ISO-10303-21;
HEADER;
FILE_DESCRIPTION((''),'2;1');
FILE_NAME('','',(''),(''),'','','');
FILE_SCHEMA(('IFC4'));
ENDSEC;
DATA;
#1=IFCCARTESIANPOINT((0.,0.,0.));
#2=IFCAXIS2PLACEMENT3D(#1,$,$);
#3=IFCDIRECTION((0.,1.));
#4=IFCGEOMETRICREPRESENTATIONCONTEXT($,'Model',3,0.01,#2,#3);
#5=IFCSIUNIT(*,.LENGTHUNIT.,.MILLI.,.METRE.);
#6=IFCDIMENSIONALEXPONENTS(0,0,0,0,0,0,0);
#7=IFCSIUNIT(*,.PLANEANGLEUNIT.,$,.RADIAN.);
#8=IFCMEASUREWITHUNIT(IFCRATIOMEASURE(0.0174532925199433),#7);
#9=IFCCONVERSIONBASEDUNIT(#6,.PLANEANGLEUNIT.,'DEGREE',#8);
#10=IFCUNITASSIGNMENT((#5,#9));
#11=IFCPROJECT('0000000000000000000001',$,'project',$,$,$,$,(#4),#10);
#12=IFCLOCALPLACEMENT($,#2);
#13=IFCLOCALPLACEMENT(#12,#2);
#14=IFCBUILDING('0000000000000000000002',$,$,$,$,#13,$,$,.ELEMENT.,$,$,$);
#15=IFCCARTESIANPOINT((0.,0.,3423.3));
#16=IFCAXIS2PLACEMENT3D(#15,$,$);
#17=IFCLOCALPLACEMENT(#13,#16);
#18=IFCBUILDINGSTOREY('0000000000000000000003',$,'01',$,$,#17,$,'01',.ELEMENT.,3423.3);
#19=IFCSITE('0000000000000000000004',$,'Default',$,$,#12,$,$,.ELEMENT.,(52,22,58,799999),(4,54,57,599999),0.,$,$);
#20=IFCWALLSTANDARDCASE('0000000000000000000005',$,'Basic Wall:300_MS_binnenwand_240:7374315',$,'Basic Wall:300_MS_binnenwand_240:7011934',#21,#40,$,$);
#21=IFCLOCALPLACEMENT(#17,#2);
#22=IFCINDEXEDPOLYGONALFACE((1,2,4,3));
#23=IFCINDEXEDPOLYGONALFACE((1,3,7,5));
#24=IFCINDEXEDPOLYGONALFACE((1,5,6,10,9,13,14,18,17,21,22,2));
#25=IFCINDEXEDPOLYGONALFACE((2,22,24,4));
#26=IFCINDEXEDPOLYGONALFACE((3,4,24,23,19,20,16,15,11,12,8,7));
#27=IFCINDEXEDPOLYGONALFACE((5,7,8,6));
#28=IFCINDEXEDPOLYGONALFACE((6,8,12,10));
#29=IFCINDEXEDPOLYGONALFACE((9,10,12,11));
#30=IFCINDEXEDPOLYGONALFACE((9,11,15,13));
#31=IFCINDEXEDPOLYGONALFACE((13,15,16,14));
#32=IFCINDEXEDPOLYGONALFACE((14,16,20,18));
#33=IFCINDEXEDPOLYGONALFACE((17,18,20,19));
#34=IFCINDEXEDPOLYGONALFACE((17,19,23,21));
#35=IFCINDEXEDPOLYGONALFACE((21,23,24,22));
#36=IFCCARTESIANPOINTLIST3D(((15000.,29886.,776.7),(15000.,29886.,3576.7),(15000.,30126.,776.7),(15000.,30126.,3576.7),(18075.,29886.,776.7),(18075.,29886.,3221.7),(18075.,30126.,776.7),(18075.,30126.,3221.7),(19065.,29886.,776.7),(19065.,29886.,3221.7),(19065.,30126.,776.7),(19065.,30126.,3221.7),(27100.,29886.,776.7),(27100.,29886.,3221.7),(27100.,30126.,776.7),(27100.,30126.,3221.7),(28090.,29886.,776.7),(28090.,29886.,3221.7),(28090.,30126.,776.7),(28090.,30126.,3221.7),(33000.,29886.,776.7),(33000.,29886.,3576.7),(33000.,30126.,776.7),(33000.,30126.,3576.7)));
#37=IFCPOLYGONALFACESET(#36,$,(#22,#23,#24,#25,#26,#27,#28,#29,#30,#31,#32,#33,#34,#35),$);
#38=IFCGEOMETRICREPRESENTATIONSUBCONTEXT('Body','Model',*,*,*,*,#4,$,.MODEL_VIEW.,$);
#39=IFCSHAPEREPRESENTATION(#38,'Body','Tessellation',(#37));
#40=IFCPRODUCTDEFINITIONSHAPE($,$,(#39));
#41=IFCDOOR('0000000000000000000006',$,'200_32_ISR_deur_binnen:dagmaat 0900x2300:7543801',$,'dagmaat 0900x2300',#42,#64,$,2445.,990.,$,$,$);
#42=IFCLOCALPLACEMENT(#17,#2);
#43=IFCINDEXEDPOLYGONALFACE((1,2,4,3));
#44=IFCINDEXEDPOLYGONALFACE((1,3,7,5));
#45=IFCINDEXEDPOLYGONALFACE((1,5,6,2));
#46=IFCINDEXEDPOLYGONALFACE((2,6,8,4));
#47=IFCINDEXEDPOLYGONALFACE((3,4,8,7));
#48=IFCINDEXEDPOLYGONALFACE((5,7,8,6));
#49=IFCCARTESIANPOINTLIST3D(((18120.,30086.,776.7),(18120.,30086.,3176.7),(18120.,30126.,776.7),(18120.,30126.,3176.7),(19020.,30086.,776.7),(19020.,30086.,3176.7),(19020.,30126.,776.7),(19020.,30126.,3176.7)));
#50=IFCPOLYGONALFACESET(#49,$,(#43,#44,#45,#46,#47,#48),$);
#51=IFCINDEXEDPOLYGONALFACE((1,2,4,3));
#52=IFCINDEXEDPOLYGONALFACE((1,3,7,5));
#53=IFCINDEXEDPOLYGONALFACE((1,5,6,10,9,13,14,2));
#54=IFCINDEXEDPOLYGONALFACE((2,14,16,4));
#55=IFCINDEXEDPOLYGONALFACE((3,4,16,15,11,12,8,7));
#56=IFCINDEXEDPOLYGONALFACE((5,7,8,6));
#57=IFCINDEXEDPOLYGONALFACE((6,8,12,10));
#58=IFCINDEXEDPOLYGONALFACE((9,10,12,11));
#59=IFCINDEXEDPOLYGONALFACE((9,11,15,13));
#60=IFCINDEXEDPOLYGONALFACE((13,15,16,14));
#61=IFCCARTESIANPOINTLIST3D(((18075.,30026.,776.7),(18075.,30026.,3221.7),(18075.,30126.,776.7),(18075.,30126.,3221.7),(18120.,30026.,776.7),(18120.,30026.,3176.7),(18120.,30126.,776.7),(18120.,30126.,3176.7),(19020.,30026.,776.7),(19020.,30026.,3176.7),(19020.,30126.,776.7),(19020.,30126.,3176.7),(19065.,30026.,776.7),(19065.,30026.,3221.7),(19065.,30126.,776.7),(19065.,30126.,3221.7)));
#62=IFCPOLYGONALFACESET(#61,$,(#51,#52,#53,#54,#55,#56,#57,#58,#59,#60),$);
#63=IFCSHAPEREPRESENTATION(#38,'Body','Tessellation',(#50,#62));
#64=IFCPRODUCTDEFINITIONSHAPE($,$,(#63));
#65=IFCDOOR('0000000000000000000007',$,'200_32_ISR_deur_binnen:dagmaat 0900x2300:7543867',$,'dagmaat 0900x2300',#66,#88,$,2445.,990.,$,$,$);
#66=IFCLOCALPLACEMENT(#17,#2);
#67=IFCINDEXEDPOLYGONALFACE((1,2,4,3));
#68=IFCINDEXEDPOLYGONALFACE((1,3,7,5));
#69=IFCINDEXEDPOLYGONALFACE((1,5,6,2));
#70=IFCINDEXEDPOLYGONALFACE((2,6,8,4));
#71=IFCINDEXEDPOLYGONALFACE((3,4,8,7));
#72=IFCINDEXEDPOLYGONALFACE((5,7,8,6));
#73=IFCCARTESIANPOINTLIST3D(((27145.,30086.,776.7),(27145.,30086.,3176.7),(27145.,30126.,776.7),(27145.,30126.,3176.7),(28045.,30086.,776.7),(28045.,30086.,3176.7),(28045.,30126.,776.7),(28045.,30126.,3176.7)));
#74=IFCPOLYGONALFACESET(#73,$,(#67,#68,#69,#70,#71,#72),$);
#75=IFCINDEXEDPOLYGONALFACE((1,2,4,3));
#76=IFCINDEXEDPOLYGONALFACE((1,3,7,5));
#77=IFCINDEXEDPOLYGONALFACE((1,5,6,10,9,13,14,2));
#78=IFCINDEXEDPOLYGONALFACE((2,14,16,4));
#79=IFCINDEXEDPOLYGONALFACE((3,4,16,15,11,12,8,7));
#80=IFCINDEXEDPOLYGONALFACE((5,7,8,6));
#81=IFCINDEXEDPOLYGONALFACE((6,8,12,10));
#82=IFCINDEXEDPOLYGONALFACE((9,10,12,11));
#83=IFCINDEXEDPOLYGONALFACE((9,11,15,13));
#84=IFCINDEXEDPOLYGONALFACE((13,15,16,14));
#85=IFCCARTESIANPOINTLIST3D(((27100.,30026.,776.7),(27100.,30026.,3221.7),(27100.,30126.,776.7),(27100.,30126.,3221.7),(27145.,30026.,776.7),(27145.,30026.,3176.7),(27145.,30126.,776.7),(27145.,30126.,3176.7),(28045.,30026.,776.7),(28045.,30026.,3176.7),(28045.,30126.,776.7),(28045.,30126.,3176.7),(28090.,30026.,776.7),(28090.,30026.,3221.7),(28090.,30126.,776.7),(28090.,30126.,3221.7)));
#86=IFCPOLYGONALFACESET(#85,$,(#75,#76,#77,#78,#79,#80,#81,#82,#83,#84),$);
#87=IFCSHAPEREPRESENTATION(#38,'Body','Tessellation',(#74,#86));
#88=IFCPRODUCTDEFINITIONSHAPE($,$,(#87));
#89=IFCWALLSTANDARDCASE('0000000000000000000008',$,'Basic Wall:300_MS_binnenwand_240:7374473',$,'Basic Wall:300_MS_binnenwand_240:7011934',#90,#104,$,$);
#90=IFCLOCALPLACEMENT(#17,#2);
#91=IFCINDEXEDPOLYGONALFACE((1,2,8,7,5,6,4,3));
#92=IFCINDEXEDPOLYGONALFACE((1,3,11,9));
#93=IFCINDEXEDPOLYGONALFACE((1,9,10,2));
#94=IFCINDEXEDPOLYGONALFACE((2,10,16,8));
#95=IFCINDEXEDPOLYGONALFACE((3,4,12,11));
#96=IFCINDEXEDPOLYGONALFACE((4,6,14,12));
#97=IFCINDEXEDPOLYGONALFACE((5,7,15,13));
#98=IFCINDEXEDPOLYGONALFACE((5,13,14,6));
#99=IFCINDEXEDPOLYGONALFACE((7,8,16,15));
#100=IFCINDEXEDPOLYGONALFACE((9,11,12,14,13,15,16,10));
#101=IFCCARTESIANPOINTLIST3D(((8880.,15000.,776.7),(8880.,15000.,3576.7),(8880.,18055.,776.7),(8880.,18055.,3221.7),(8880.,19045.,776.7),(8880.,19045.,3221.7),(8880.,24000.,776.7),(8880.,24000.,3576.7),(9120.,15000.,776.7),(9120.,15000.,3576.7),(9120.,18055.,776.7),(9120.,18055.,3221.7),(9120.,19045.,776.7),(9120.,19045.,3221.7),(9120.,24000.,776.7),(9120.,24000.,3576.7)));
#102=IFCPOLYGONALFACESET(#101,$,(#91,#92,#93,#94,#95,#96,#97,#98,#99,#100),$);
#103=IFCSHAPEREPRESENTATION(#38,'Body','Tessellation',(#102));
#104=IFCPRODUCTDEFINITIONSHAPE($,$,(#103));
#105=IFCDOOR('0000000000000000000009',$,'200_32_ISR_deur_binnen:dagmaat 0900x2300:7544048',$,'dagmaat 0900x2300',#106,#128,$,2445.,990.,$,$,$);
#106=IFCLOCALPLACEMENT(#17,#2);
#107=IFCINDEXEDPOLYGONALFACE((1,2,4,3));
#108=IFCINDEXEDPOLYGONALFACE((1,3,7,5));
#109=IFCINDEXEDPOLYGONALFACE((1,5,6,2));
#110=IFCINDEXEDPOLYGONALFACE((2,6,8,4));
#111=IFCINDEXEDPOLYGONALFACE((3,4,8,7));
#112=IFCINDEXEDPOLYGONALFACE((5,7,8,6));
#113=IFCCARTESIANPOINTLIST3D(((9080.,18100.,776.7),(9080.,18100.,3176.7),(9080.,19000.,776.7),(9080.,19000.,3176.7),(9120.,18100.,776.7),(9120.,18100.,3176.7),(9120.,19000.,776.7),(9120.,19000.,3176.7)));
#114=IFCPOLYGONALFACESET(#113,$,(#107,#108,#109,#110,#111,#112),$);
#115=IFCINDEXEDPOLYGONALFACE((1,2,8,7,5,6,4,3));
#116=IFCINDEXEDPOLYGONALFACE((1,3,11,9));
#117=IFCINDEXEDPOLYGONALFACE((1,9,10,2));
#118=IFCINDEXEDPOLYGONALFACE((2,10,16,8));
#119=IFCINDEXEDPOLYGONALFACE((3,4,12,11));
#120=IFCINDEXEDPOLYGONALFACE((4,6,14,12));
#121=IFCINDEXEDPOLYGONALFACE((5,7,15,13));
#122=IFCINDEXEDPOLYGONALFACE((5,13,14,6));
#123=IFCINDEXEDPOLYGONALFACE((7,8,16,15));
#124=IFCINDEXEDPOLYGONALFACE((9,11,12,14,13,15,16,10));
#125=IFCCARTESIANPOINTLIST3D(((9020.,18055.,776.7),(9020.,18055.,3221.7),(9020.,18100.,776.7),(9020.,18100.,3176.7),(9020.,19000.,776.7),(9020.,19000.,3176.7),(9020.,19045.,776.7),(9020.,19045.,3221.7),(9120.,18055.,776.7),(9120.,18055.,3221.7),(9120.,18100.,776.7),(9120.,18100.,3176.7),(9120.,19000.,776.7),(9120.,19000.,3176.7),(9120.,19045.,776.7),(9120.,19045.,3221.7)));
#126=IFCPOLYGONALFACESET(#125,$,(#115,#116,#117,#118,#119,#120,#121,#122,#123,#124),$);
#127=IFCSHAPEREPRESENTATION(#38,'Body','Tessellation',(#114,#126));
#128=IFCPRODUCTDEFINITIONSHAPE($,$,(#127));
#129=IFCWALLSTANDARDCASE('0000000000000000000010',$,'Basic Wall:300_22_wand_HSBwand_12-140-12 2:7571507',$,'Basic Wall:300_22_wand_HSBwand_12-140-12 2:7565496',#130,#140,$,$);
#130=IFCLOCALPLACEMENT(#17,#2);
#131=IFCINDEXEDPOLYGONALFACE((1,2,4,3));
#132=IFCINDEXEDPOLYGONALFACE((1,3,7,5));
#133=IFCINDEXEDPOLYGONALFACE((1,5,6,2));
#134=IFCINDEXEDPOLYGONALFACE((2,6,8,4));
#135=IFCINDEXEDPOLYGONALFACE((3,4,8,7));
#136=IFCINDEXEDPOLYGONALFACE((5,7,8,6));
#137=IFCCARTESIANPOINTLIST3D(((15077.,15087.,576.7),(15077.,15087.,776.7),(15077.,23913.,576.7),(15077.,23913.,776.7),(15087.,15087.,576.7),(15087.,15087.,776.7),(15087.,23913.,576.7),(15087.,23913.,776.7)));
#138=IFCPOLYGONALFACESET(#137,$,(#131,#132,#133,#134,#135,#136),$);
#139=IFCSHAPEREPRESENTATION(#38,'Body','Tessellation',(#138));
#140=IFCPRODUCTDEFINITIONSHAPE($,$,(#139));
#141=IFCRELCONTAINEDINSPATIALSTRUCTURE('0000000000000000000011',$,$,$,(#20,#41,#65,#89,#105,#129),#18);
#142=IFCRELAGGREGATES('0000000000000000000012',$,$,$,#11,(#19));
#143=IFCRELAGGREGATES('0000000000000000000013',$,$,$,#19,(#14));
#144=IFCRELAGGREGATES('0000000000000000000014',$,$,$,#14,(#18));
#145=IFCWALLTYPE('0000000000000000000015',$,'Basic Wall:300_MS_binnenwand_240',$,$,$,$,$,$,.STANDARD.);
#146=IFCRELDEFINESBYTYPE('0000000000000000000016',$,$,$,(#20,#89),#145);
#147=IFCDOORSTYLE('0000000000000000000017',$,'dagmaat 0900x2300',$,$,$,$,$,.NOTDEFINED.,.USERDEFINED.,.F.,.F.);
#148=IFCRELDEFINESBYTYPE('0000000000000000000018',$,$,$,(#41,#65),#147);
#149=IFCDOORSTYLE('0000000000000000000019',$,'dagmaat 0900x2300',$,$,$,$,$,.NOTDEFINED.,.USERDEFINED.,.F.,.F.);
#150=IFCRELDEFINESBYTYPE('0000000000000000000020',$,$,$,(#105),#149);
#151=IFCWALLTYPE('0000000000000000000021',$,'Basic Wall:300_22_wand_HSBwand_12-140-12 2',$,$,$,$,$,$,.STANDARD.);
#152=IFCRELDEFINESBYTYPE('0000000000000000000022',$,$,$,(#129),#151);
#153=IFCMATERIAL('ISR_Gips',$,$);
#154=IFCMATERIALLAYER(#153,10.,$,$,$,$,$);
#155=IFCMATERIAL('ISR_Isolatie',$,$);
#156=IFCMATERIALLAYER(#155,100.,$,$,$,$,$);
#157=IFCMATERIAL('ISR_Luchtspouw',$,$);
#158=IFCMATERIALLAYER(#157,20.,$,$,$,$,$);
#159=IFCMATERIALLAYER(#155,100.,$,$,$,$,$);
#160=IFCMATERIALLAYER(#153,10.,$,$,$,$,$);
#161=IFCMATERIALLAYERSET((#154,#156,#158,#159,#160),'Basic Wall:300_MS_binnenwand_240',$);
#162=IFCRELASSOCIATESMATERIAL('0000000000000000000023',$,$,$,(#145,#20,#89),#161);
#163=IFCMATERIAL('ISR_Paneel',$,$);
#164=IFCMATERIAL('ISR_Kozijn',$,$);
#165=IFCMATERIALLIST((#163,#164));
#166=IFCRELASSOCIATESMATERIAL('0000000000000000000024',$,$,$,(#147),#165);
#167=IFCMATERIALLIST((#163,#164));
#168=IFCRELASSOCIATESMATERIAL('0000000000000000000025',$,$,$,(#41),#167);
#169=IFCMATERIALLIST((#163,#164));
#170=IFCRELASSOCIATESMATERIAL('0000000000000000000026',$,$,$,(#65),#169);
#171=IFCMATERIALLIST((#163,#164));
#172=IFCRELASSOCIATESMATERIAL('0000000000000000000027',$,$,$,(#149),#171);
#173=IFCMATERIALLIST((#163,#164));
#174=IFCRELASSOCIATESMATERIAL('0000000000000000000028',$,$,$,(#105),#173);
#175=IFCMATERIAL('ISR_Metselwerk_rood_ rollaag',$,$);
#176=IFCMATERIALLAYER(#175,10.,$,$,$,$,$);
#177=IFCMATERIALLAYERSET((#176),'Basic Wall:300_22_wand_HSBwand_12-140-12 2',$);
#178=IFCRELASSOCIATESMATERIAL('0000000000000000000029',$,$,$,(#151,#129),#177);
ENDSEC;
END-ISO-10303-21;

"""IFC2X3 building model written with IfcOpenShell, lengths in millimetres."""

from ifc_helpers import new_model, entity, si_unit, converted_unit, direction, frame, frame_2d, origin, origin_2d_with_axis, place, context, subcontext, project, spatial, polyline, rectangle, outline, extrude, source, transform, mapped, material, material_list, layer, layer_set, layer_usage, type_object, type_shapes, element, fill, save


model = new_model("IFC2X3")

# Units and contexts
model_context = context("Model", 3, precision=0.01, world=origin(), true_north=direction((0.0, 1.0)))
body_context = subcontext(model_context, "Body", "Model", "MODEL_VIEW")
ifc_project = project(units=[si_unit("LENGTHUNIT", "METRE", prefix="MILLI"), converted_unit("PLANEANGLEUNIT", "DEGREE", entity("IfcRatioMeasure", 0.0174532925199433), si_unit("PLANEANGLEUNIT", "RADIAN"), dimensions=[0, 0, 0, 0, 0, 0, 0])], contexts=[model_context])

# Site, building, storey
site_placement = place(None, origin())
site = spatial("IfcSite", under=ifc_project, at=site_placement, Name="Default", CompositionType="ELEMENT", RefLatitude=(52, 22, 58, 799999), RefLongitude=(4, 54, 57, 599999), RefElevation=0.0)
building_placement = place(site_placement, origin())
building = spatial("IfcBuilding", under=site, at=building_placement, CompositionType="ELEMENT")
storey_placement = place(building_placement, frame((0.0, 0.0, 3423.3)))
storey = spatial("IfcBuildingStorey", under=building, at=storey_placement, Name="01", LongName="01", CompositionType="ELEMENT", Elevation=3423.3)

# Shared definitions
ifc_material_1 = material(Name="ISR_Gips")
ifc_layer_1 = layer(ifc_material_1, 10.0)
ifc_material_2 = material(Name="ISR_Isolatie")
ifc_layer_2 = layer(ifc_material_2, 100.0)
ifc_material_3 = material(Name="ISR_Luchtspouw")
ifc_layer_3 = layer(ifc_material_3, 20.0)
ifc_layer_4 = layer(ifc_material_2, 100.0)
ifc_layer_5 = layer(ifc_material_1, 10.0)
ifc_layer_set_1 = layer_set([ifc_layer_1, ifc_layer_2, ifc_layer_3, ifc_layer_4, ifc_layer_5], Name="Basic Wall:300_MS_binnenwand_240")
wall_type_1 = type_object("IfcWallType", Name="Basic Wall:300_MS_binnenwand_240", PredefinedType="STANDARD", material=ifc_layer_set_1)
ifc_material_4 = material(Name="ISR_Paneel")
ifc_material_5 = material(Name="ISR_Kozijn")
ifc_material_list_1 = material_list([ifc_material_4, ifc_material_5])
door_style_1 = type_object("IfcDoorStyle", Name="dagmaat 0900x2300", ConstructionType="USERDEFINED", OperationType="NOTDEFINED", ParameterTakesPrecedence=False, Sizeable=False, material=ifc_material_list_1)
shared_shape_1 = source(origin(), body_context, "Body", "SweptSolid", [
    extrude(rectangle(XDim=900.0, YDim=40.0, at=origin_2d_with_axis()), frame((495.0, 220.0, 0.0)), (0.0, 0.0, 1.0), 2400.0),
    extrude(outline(polyline([(-1211.2, -450.0), (-1211.2, -495.0), (1233.7, -495.0), (1233.7, 495.0), (-1211.2, 495.0), (-1211.2, 450.0), (1188.8, 450.0), (1188.8, -450.0), (-1211.2, -450.0)])), frame((495.0, 140.0, 1211.2), z_axis=(0.0, -1.0, 0.0), x_axis=(0.0, 0.0, 1.0)), (0.0, 0.0, -1.0), 100.0),
])
type_shapes(door_style_1, [shared_shape_1])

# Wall, openings, doors
ifc_layer_usage_1 = layer_usage(ifc_layer_set_1, "AXIS2", "POSITIVE", -120.0)
wall_1_placement = place(storey_placement, frame((15000.0, 30006.0, 776.7)))
wall_1 = element("IfcWallStandardCase", 1, at=wall_1_placement, inside=storey, type_object=wall_type_1, material=ifc_layer_usage_1, Name="Basic Wall:300_MS_binnenwand_240:7374315", ObjectType="Basic Wall:300_MS_binnenwand_240:7011934", context=body_context, shape_type="SweptSolid", body=[
    extrude(rectangle(XDim=18000.0, YDim=240.0, at=frame_2d((9000.0, 0.0), x_axis=(-1.0, 0.0))), origin(), (0.0, 0.0, 1.0), 2800.0),
])
opening_1_placement = place(wall_1_placement, frame((3075.0, -120.0, 0.0)))
opening_1 = element("IfcOpeningElement", 2, at=opening_1_placement, cuts=wall_1, ObjectType="Opening", context=body_context, shape_type="SweptSolid", body=[
    extrude(rectangle(XDim=2445.0, YDim=990.0, at=frame_2d((1222.5, 495.0), x_axis=(-1.0, 0.0))), frame((0.0, 0.0, 0.0), z_axis=(0.0, 1.0, 0.0), x_axis=(0.0, 0.0, 1.0)), (0.0, 0.0, 1.0), 240.0),
])
opening_2_placement = place(wall_1_placement, frame((12100.0, -120.0, 0.0)))
opening_2 = element("IfcOpeningElement", 3, at=opening_2_placement, cuts=wall_1, ObjectType="Opening", context=body_context, shape_type="SweptSolid", body=[
    extrude(rectangle(XDim=2445.0, YDim=990.0, at=frame_2d((1222.5, 495.0), x_axis=(-1.0, 0.0))), frame((0.0, 0.0, 0.0), z_axis=(0.0, 1.0, 0.0), x_axis=(0.0, 0.0, 1.0)), (0.0, 0.0, 1.0), 240.0),
])
ifc_material_list_2 = material_list([ifc_material_4, ifc_material_5])
door_1_placement = place(opening_1_placement, origin())
door_1 = element("IfcDoor", 4, at=door_1_placement, inside=storey, type_object=door_style_1, material=ifc_material_list_2, Name="200_32_ISR_deur_binnen:dagmaat 0900x2300:7543801", ObjectType="dagmaat 0900x2300", OverallHeight=2445.0, OverallWidth=990.0, context=body_context, shape_type="MappedRepresentation", body=[
    mapped(shared_shape_1, transform((0.0, 0.0, 0.0), scale=1.0)),
])
fill(opening_1, door_1)
ifc_material_list_3 = material_list([ifc_material_4, ifc_material_5])
door_2_placement = place(opening_2_placement, origin())
door_2 = element("IfcDoor", 5, at=door_2_placement, inside=storey, type_object=door_style_1, material=ifc_material_list_3, Name="200_32_ISR_deur_binnen:dagmaat 0900x2300:7543867", ObjectType="dagmaat 0900x2300", OverallHeight=2445.0, OverallWidth=990.0, context=body_context, shape_type="MappedRepresentation", body=[
    mapped(shared_shape_1, transform((0.0, 0.0, 0.0), scale=1.0)),
])
fill(opening_2, door_2)

# Wall, opening, door
ifc_layer_usage_2 = layer_usage(ifc_layer_set_1, "AXIS2", "NEGATIVE", 120.0)
wall_2_placement = place(storey_placement, frame((9000.0, 24000.0, 776.7), z_axis=(0.0, 0.0, 1.0), x_axis=(0.0, -1.0, 0.0)))
wall_2 = element("IfcWallStandardCase", 6, at=wall_2_placement, inside=storey, type_object=wall_type_1, material=ifc_layer_usage_2, Name="Basic Wall:300_MS_binnenwand_240:7374473", ObjectType="Basic Wall:300_MS_binnenwand_240:7011934", context=body_context, shape_type="SweptSolid", body=[
    extrude(rectangle(XDim=9000.0, YDim=240.0, at=frame_2d((4500.0, 0.0), x_axis=(-1.0, 0.0))), origin(), (0.0, 0.0, 1.0), 2800.0),
])
opening_3_placement = place(wall_2_placement, frame((4955.0, -120.0, 0.0)))
opening_3 = element("IfcOpeningElement", 7, at=opening_3_placement, cuts=wall_2, ObjectType="Opening", context=body_context, shape_type="SweptSolid", body=[
    extrude(rectangle(XDim=2445.0, YDim=990.0, at=frame_2d((1222.5, 495.0), x_axis=(-1.0, 0.0))), frame((0.0, 0.0, 0.0), z_axis=(0.0, 1.0, 0.0), x_axis=(0.0, 0.0, 1.0)), (0.0, 0.0, 1.0), 240.0),
])
ifc_material_list_4 = material_list([ifc_material_4, ifc_material_5])
ifc_material_list_5 = material_list([ifc_material_4, ifc_material_5])
door_style_2 = type_object("IfcDoorStyle", Name="dagmaat 0900x2300", ConstructionType="USERDEFINED", OperationType="NOTDEFINED", ParameterTakesPrecedence=False, Sizeable=False, material=ifc_material_list_5)
shared_shape_2 = source(origin(), body_context, "Body", "SweptSolid", [
    extrude(rectangle(XDim=40.0, YDim=900.0, at=frame_2d((0.0, 0.0), x_axis=(1.0, 0.0))), frame((495.0, 220.0, 0.0), z_axis=(0.0, 0.0, 1.0), x_axis=(0.0, 1.0, 0.0)), (0.0, 0.0, 1.0), 2400.0),
    extrude(outline(polyline([(-1211.2, -450.0), (-1211.2, -495.0), (1233.7, -495.0), (1233.7, 495.0), (-1211.2, 495.0), (-1211.2, 450.0), (1188.8, 450.0), (1188.8, -450.0), (-1211.2, -450.0)])), frame((495.0, 240.0, 1211.2), z_axis=(0.0, 1.0, 0.0), x_axis=(0.0, 0.0, 1.0)), (0.0, 0.0, -1.0), 100.0),
])
type_shapes(door_style_2, [shared_shape_2])
door_3_placement = place(opening_3_placement, origin())
door_3 = element("IfcDoor", 8, at=door_3_placement, inside=storey, type_object=door_style_2, material=ifc_material_list_4, Name="200_32_ISR_deur_binnen:dagmaat 0900x2300:7544048", ObjectType="dagmaat 0900x2300", OverallHeight=2445.0, OverallWidth=990.0, context=body_context, shape_type="MappedRepresentation", body=[
    mapped(shared_shape_2, transform((0.0, 0.0, 0.0), scale=1.0)),
])
fill(opening_3, door_3)

# Wall
ifc_material_6 = material(Name="ISR_Metselwerk_rood_ rollaag")
ifc_layer_6 = layer(ifc_material_6, 10.0)
ifc_layer_set_2 = layer_set([ifc_layer_6], Name="Basic Wall:300_22_wand_HSBwand_12-140-12 2")
ifc_layer_usage_3 = layer_usage(ifc_layer_set_2, "AXIS2", "NEGATIVE", 5.0)
wall_type_2 = type_object("IfcWallType", Name="Basic Wall:300_22_wand_HSBwand_12-140-12 2", PredefinedType="STANDARD", material=ifc_layer_set_2)
wall_3_placement = place(storey_placement, frame((15082.0, 23913.0, 576.7), z_axis=(0.0, 0.0, 1.0), x_axis=(0.0, -1.0, 0.0)))
element("IfcWallStandardCase", 9, at=wall_3_placement, inside=storey, type_object=wall_type_2, material=ifc_layer_usage_3, Name="Basic Wall:300_22_wand_HSBwand_12-140-12 2:7571507", ObjectType="Basic Wall:300_22_wand_HSBwand_12-140-12 2:7565496", context=body_context, shape_type="SweptSolid", body=[
    extrude(rectangle(XDim=8826.0, YDim=10.0, at=frame_2d((4413.0, 0.0), x_axis=(-1.0, 0.0))), origin(), (0.0, 0.0, 1.0), 200.0),
])

save(model, "model.ifc")
